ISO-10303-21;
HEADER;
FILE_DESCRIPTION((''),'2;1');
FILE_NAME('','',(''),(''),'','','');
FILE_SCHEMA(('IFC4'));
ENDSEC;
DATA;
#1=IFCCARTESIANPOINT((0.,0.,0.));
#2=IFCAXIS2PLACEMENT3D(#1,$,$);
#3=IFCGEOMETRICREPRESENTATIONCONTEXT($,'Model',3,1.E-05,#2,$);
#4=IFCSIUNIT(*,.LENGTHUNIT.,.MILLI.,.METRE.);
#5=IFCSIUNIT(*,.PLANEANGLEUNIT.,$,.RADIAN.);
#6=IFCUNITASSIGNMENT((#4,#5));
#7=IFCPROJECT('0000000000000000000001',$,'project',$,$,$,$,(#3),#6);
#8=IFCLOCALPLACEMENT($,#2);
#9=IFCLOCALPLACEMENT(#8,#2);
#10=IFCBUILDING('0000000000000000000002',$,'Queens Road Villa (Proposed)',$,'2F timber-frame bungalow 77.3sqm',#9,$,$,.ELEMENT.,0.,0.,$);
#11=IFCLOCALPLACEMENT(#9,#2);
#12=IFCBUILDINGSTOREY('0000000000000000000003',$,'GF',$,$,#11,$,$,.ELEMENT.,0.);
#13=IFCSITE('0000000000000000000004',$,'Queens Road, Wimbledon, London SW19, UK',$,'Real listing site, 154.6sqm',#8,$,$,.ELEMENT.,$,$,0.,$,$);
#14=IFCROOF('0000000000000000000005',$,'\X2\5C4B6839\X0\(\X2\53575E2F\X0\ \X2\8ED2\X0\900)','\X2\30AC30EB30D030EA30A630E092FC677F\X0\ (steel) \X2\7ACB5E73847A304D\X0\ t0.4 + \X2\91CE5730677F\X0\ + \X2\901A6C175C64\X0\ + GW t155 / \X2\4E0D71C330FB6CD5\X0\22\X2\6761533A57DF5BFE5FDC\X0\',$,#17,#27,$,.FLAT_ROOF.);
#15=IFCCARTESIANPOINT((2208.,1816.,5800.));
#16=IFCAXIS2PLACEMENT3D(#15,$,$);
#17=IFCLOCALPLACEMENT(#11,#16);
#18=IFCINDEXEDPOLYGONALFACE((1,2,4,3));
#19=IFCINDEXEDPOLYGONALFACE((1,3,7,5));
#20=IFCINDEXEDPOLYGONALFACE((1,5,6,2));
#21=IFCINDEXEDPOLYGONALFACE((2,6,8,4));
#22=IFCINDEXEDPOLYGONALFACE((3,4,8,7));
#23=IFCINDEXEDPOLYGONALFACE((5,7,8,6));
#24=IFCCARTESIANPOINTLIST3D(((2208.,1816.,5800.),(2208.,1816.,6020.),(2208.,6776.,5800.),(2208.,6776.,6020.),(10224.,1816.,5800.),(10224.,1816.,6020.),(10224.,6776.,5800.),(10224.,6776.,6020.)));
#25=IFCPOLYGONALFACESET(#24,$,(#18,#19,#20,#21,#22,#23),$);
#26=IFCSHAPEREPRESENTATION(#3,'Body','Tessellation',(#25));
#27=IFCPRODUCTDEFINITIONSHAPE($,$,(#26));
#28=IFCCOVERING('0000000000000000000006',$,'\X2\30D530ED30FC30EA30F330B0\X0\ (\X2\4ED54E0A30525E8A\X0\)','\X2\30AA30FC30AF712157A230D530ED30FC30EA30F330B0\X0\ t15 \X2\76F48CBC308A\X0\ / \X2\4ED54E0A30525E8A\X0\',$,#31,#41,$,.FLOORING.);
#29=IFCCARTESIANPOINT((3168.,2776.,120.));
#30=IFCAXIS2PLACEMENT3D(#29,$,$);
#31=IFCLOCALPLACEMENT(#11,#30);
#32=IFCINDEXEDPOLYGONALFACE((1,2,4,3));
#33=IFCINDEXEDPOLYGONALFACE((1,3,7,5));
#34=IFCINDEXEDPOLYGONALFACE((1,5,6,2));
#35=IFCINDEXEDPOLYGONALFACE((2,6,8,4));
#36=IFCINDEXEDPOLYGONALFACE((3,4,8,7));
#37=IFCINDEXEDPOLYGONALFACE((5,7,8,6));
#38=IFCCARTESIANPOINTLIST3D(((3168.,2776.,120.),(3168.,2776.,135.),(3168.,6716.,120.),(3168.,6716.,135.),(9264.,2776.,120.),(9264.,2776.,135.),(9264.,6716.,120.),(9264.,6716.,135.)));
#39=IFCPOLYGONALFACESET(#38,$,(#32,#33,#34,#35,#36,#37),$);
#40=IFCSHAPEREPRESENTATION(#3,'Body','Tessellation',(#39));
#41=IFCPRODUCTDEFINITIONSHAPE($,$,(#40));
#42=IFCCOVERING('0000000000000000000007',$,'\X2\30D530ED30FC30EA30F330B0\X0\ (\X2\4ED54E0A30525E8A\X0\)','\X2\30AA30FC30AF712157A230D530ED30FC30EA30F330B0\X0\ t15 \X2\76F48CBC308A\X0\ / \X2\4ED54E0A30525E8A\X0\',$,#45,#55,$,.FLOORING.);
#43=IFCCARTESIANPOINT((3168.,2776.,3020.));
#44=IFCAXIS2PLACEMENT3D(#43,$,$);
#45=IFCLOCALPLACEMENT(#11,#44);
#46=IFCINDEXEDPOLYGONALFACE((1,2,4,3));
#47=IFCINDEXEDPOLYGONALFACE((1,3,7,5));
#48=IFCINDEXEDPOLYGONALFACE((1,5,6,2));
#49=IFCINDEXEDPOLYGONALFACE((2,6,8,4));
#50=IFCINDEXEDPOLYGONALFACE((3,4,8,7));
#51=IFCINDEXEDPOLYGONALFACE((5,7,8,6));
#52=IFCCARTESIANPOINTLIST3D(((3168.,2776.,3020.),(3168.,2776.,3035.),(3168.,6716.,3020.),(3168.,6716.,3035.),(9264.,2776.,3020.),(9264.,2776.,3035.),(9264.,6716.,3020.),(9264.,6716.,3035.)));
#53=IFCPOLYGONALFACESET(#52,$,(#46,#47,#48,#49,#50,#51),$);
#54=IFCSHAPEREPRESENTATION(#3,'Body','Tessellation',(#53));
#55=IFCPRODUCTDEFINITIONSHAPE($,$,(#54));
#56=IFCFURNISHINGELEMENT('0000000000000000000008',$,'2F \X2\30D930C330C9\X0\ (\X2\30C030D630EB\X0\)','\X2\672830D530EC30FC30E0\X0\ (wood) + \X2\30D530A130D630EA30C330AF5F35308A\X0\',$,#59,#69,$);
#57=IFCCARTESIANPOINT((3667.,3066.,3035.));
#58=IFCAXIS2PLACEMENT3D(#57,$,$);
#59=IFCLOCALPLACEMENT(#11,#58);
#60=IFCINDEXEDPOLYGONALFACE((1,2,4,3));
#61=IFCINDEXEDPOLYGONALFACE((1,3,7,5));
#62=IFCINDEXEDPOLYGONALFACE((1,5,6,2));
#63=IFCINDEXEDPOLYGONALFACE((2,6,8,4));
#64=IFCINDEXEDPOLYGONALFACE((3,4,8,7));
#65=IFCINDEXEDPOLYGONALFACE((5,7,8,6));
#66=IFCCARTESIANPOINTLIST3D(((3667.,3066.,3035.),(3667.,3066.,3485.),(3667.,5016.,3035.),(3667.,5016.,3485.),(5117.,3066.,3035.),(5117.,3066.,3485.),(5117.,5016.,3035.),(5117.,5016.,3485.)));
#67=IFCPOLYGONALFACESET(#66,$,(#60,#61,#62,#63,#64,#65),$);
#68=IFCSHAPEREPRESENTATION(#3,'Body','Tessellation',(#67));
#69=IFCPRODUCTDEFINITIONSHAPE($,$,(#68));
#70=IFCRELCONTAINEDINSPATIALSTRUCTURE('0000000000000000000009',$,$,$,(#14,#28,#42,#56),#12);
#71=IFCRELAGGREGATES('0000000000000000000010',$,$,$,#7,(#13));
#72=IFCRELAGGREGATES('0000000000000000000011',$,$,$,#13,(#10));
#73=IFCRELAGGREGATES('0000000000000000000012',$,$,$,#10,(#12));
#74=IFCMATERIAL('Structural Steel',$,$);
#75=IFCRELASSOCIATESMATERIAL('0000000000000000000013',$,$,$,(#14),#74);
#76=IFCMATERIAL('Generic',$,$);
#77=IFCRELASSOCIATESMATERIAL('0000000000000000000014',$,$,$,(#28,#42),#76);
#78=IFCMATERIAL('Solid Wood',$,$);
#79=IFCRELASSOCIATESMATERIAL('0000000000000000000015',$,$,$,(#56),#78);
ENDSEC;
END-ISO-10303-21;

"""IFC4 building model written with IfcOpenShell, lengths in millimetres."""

from ifc_helpers import new_model, si_unit, frame, frame_2d, origin, place, context, project, spatial, rectangle, extrude, material, element, save


model = new_model("IFC4")

# Units and contexts
model_context = context("Model", 3, precision=1e-05, world=origin())
ifc_project = project(units=[si_unit("LENGTHUNIT", "METRE", prefix="MILLI"), si_unit("PLANEANGLEUNIT", "RADIAN")], contexts=[model_context])

# Site, building, storey
site_placement = place(None, origin())
site = spatial("IfcSite", under=ifc_project, at=site_placement, Name="Queens Road, Wimbledon, London SW19, UK", ObjectType="Real listing site, 154.6sqm", CompositionType="ELEMENT", RefElevation=0.0)
building_placement = place(site_placement, origin())
building = spatial("IfcBuilding", under=site, at=building_placement, Name="Queens Road Villa (Proposed)", ObjectType="2F timber-frame bungalow 77.3sqm", CompositionType="ELEMENT", ElevationOfRefHeight=0.0, ElevationOfTerrain=0.0)
storey_placement = place(building_placement, origin())
storey = spatial("IfcBuildingStorey", under=building, at=storey_placement, Name="GF", CompositionType="ELEMENT", Elevation=0.0)

# Shared definitions
ifc_material_1 = material(Name="Solid Wood")

# Roof
ifc_material_2 = material(Name="Structural Steel")
for number, where, name in (
    (1, (2208.0, 1816.0, 5800.0), "屋根(南帯 軒900)"),
):
    element("IfcRoof", number, at=place(storey_placement, frame(where)), inside=storey, material=ifc_material_2, Name=name, Description="ガルバリウム鋼板 (steel) 立平葺き t0.4 + 野地板 + 通気層 + GW t155 / 不燃・法22条区域対応", PredefinedType="FLAT_ROOF", context=model_context, shape_type="SweptSolid", body=[
        extrude(rectangle(XDim=8016.0, YDim=4960.0, at=frame_2d((4008.0, 2480.0))), frame((2208.0, 1816.0, 5800.0)), (0.0, 0.0, 1.0), 220.0),
    ])

# Coverings
ifc_material_3 = material(Name="Generic")
covering_1_placement = place(storey_placement, frame((3168.0, 2776.0, 120.0)))
element("IfcCovering", 2, at=covering_1_placement, inside=storey, material=ifc_material_3, Name="フローリング (仕上げ床)", Description="オーク無垢フローリング t15 直貼り / 仕上げ床", PredefinedType="FLOORING", context=model_context, shape_type="SweptSolid", body=[
    extrude(rectangle(XDim=6096.0, YDim=3940.0, at=frame_2d((3048.0, 1970.0))), frame((3168.0, 2776.0, 120.0)), (0.0, 0.0, 1.0), 15.0),
])
covering_2_placement = place(storey_placement, frame((3168.0, 2776.0, 3020.0)))
element("IfcCovering", 3, at=covering_2_placement, inside=storey, material=ifc_material_3, Name="フローリング (仕上げ床)", Description="オーク無垢フローリング t15 直貼り / 仕上げ床", PredefinedType="FLOORING", context=model_context, shape_type="SweptSolid", body=[
    extrude(rectangle(XDim=6096.0, YDim=3940.0, at=frame_2d((3048.0, 1970.0))), frame((3168.0, 2776.0, 3020.0)), (0.0, 0.0, 1.0), 15.0),
])

# Furnishing element
furnishing_placement = place(storey_placement, frame((3667.0, 3066.0, 3035.0)))
element("IfcFurnishingElement", 4, at=furnishing_placement, inside=storey, material=ifc_material_1, Name="2F ベッド (ダブル)", Description="木フレーム (wood) + ファブリック張り", context=model_context, shape_type="SweptSolid", body=[
    extrude(rectangle(XDim=1450.0, YDim=1950.0, at=frame_2d((725.0, 975.0))), frame((3667.0, 3066.0, 3035.0)), (0.0, 0.0, 1.0), 450.0),
])

save(model, "model.ifc")
